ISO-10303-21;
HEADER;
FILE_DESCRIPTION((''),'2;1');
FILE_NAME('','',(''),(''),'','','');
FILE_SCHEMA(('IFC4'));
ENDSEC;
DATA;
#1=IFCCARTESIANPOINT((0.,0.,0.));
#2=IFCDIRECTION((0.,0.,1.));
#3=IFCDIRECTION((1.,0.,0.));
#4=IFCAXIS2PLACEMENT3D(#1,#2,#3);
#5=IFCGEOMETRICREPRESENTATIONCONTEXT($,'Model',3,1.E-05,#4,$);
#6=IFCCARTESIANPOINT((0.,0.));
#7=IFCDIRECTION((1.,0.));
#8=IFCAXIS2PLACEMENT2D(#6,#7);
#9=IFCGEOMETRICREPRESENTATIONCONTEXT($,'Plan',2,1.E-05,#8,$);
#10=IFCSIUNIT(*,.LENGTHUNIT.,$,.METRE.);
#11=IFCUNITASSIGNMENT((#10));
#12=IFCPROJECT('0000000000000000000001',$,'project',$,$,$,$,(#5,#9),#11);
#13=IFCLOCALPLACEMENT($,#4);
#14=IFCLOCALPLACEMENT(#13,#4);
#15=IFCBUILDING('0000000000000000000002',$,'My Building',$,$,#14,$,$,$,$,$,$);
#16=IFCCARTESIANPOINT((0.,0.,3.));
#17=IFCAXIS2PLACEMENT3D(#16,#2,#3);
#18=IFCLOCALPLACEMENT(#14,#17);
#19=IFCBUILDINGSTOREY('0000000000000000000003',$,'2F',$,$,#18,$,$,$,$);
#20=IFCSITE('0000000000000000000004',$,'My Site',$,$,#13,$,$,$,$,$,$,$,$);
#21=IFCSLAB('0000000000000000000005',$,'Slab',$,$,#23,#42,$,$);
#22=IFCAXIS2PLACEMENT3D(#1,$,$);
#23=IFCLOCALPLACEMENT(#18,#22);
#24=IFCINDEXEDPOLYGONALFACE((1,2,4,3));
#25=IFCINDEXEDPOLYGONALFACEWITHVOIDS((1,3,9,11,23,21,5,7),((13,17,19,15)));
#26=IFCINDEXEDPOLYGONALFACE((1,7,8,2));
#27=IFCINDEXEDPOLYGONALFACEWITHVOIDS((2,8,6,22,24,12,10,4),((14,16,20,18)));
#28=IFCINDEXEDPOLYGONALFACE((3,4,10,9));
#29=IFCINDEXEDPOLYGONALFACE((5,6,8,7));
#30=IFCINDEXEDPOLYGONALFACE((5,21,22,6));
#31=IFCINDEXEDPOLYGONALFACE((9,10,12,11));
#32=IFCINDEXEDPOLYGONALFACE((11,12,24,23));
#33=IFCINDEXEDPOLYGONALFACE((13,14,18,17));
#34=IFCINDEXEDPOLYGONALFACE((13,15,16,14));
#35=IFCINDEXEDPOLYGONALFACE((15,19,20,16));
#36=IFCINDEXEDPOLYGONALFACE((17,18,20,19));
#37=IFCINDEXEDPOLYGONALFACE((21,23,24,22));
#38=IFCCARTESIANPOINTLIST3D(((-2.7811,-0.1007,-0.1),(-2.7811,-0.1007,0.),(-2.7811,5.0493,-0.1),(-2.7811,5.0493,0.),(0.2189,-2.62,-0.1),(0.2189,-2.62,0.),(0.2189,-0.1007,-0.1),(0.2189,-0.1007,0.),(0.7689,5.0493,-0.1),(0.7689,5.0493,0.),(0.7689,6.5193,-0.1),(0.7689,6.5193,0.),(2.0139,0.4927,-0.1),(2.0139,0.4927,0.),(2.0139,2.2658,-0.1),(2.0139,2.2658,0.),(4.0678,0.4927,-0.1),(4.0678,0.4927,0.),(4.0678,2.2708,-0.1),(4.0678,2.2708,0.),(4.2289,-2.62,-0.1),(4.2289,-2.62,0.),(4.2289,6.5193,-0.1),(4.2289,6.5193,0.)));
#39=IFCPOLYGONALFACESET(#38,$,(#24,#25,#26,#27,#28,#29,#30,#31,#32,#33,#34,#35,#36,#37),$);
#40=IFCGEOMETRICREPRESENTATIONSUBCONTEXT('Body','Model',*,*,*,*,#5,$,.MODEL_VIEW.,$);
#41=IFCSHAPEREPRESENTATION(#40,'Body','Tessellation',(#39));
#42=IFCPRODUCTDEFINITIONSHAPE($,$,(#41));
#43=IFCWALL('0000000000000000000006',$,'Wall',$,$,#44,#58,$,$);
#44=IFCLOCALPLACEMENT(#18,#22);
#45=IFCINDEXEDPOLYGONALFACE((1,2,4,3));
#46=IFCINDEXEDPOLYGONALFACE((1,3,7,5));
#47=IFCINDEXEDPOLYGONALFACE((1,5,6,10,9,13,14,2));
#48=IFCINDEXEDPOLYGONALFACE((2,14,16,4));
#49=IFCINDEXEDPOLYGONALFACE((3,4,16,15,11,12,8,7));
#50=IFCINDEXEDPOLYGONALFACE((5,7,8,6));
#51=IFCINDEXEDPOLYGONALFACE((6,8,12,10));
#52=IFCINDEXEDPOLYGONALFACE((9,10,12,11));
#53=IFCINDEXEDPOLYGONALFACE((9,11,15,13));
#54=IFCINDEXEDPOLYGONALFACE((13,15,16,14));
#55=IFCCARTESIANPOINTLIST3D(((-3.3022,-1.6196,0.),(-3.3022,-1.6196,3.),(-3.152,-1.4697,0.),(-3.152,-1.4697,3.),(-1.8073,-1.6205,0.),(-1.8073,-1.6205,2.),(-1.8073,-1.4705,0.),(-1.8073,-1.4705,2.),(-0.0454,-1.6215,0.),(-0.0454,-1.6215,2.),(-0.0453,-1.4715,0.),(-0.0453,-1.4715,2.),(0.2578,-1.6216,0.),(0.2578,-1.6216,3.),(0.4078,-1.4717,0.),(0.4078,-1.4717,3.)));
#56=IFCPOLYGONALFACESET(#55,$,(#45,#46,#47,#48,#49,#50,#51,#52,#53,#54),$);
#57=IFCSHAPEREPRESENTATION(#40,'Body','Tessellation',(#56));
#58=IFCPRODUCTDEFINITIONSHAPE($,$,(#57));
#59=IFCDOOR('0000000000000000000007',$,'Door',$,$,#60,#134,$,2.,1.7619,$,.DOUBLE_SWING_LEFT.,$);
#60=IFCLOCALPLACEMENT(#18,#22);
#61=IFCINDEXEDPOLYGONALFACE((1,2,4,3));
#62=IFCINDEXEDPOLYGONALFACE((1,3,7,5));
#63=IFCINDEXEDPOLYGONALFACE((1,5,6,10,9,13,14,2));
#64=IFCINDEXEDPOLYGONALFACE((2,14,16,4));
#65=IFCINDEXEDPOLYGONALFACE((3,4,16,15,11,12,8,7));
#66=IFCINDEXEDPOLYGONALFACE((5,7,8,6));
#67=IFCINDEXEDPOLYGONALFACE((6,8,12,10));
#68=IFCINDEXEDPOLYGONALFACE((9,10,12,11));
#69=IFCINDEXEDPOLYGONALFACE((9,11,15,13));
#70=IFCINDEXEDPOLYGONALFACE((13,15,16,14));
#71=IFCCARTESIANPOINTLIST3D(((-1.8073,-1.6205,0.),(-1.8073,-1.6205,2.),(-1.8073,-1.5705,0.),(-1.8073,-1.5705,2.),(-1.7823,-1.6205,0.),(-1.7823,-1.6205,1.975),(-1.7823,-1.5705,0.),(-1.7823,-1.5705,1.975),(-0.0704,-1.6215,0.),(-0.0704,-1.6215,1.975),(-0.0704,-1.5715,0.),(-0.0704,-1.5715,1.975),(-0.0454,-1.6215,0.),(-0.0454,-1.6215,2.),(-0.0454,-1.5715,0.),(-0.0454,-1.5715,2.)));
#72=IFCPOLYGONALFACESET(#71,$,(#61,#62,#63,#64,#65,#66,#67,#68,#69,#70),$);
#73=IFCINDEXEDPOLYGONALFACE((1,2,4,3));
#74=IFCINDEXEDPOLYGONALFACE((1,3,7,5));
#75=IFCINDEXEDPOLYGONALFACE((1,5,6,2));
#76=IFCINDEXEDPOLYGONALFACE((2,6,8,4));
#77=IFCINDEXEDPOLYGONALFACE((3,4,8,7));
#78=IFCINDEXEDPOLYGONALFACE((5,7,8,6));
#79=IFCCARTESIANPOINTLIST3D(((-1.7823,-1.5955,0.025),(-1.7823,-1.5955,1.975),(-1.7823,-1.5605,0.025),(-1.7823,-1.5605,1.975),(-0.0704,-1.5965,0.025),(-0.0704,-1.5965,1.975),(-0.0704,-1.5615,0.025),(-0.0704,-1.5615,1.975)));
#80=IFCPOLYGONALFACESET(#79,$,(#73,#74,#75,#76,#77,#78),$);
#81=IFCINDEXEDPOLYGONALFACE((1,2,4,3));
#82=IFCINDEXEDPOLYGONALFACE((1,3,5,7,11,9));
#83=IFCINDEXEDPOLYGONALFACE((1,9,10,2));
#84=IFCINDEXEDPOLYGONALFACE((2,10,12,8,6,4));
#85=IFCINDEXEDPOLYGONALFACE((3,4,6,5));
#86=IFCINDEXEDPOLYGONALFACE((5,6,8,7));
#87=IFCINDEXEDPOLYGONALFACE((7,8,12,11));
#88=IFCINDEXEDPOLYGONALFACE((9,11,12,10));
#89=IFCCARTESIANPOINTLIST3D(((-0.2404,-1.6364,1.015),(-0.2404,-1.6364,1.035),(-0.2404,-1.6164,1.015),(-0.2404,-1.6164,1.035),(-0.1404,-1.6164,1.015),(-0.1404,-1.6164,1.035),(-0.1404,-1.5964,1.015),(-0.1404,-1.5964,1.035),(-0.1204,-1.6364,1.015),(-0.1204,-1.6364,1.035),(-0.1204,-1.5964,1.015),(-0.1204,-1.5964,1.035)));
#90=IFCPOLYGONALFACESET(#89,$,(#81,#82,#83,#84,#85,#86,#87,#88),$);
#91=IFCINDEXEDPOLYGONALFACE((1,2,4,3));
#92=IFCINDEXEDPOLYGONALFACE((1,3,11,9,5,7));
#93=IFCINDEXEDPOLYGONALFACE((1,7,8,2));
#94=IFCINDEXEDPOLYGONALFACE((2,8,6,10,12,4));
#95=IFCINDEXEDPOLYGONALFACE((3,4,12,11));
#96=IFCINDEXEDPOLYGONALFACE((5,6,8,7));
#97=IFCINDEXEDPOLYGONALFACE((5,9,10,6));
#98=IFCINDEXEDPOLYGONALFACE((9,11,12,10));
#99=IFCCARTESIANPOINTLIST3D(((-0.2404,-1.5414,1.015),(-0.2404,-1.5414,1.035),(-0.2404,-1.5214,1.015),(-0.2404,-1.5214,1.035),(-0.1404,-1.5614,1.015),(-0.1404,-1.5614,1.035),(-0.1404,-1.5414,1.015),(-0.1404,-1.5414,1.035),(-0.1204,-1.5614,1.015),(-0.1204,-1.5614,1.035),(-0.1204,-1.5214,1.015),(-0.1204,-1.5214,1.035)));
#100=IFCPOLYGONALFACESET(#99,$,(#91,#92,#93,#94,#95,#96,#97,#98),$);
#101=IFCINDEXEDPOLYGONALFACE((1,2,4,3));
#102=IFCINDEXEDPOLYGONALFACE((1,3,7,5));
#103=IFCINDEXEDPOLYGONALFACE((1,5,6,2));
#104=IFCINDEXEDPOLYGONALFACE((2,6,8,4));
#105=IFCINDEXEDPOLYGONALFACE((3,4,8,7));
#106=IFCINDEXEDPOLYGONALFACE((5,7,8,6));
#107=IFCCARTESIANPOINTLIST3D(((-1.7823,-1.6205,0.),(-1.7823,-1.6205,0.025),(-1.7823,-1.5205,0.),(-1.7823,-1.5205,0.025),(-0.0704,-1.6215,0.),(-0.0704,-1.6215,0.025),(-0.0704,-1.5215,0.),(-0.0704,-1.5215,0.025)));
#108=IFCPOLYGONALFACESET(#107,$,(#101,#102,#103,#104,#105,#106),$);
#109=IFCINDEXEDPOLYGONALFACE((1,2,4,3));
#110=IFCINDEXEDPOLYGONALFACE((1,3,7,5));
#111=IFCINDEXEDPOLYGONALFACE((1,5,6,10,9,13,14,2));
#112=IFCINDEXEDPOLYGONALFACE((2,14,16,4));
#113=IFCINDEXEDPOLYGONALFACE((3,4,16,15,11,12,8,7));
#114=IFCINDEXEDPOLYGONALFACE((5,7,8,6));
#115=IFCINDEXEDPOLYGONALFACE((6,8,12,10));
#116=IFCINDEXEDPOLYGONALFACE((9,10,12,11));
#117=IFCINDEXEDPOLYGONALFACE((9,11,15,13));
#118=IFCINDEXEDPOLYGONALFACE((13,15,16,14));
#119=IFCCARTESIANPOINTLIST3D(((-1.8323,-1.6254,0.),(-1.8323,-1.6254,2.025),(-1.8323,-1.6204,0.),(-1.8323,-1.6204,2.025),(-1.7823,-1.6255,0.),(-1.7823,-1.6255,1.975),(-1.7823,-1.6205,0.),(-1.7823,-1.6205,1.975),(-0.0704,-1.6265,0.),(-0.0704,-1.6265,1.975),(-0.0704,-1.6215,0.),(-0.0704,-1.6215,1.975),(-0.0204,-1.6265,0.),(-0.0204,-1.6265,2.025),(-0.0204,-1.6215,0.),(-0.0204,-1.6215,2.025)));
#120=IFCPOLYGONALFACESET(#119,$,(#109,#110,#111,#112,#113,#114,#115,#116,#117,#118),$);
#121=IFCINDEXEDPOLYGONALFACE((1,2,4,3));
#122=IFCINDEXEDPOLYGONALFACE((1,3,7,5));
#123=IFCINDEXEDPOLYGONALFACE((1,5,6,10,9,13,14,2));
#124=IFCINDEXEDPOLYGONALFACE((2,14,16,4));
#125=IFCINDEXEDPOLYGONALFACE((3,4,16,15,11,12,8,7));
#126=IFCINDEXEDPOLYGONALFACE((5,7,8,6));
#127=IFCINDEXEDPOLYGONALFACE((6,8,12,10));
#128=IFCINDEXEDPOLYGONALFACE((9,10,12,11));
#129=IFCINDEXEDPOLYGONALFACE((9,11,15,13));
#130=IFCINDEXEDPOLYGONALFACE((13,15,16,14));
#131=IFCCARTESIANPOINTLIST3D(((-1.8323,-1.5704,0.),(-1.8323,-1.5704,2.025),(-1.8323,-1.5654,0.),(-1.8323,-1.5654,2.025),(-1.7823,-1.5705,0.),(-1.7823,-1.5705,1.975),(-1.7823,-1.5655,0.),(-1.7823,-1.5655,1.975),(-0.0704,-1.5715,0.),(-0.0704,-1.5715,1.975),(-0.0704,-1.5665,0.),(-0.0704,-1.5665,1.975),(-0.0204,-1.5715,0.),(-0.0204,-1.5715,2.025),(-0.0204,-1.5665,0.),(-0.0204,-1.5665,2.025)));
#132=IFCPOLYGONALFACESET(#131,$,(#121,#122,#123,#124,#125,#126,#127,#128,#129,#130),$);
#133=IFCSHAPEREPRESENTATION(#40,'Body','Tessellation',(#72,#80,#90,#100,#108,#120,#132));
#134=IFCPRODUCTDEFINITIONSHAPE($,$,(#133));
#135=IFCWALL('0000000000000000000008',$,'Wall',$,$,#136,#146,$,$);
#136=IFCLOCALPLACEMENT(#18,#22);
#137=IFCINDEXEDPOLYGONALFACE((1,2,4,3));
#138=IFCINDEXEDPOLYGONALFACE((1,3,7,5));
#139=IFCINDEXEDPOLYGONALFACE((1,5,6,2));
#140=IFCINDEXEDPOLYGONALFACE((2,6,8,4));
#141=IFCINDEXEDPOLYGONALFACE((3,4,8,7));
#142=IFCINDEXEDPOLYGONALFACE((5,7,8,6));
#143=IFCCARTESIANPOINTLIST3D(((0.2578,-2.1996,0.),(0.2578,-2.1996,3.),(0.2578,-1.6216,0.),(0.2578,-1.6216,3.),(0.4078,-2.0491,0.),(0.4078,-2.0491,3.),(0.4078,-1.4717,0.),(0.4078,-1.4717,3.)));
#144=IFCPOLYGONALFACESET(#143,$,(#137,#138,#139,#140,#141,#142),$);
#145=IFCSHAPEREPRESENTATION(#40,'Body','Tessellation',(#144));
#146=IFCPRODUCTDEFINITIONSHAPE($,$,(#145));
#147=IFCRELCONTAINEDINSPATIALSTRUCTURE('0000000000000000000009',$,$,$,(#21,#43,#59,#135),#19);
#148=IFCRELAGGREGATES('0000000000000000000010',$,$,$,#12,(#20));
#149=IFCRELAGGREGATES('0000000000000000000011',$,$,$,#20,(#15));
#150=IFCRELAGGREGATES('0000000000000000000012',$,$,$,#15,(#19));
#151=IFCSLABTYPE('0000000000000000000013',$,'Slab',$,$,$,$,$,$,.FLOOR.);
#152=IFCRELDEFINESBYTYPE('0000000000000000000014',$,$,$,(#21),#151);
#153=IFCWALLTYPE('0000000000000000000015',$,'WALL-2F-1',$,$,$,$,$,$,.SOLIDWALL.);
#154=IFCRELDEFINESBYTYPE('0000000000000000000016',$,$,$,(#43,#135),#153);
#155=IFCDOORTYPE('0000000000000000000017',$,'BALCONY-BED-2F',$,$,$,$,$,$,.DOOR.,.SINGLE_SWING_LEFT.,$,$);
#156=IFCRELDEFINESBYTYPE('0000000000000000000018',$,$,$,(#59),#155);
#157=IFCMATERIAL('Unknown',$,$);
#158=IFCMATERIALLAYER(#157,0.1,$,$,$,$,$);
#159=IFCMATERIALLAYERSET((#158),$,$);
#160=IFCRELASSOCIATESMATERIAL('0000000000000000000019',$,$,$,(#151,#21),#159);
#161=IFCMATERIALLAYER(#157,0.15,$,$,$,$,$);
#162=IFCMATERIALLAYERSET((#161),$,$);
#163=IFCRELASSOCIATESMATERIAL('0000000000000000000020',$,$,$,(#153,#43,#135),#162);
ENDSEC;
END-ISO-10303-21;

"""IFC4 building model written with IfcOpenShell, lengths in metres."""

from ifc_helpers import new_model, entity, si_unit, frame, origin_with_axes, origin_2d_with_axis, place, context, subcontext, project, spatial, line, indexed_curve, outline, extrude, shape, source, transform, mapped, material, layer, layer_set, layer_usage, type_object, type_shapes, element, fill, save


model = new_model("IFC4")

# Units and contexts
model_context = context("Model", 3, precision=1e-05, world=origin_with_axes())
plan_context = context("Plan", 2, precision=1e-05, world=origin_2d_with_axis())
body_context_1 = subcontext(model_context, "Body", "Model", "MODEL_VIEW")
body_context_2 = subcontext(plan_context, "Body", "Plan", "PLAN_VIEW")
ifc_project = project(units=[si_unit("LENGTHUNIT", "METRE")], contexts=[model_context, plan_context])

# Site, building, storey
site_placement = place(None, origin_with_axes())
site = spatial("IfcSite", under=ifc_project, at=site_placement, Name="My Site")
building_placement = place(site_placement, origin_with_axes())
building = spatial("IfcBuilding", under=site, at=building_placement, Name="My Building")
storey_placement = place(building_placement, frame((0.0, 0.0, 3.0), z_axis=(0.0, 0.0, 1.0), x_axis=(1.0, 0.0, 0.0)))
storey = spatial("IfcBuildingStorey", under=building, at=storey_placement, Name="2F")

# Slab
ifc_material = material(Name="Unknown")
ifc_layer_1 = layer(ifc_material, 0.1)
ifc_layer_set_1 = layer_set([ifc_layer_1])
ifc_layer_usage_1 = layer_usage(ifc_layer_set_1, "AXIS3", "POSITIVE", -0.1)
slab_type = type_object("IfcSlabType", Name="Slab", PredefinedType="FLOOR", material=ifc_layer_set_1)
slab_placement = place(storey_placement, frame((0.2189, -2.62, 0.0), z_axis=(0.0, 0.0, 1.0), x_axis=(1.0, 0.0, 0.0)))
element("IfcSlab", 1, at=slab_placement, inside=storey, type_object=slab_type, material=ifc_layer_usage_1, Name="Slab", context=body_context_1, shape_type="SweptSolid", body=[
    extrude(outline(indexed_curve([(0.0, 0.0), (4.01, 0.0), (4.01, 9.1393), (0.55, 9.1393), (0.55, 7.6693), (-3.0, 7.6693), (-3.0, 2.5193), (0.0, 2.5193), (0.0, 0.0)]), holes=[indexed_curve([(1.7949, 4.8858), (3.8489, 4.8908), (3.8489, 3.1127), (1.7949, 3.1127), (1.7949, 4.8858)])]), frame((0.0, 0.0, -0.1), z_axis=(0.0, 0.0, 1.0), x_axis=(1.0, 0.0, 0.0)), (0.0, 0.0, 1.0), 0.1),
])

# Wall, opening, door
ifc_layer_2 = layer(ifc_material, 0.15)
ifc_layer_set_2 = layer_set([ifc_layer_2])
ifc_layer_usage_2 = layer_usage(ifc_layer_set_2, "AXIS2", "POSITIVE", 0.0)
wall_type_1 = type_object("IfcWallType", Name="WALL-2F-1", PredefinedType="SOLIDWALL", material=ifc_layer_set_2)
wall_1_placement = place(storey_placement, frame((-3.3022, -1.6196, 0.0), z_axis=(0.0, 0.0, 1.0), x_axis=(1.0, -0.00057, 0.0)))
wall_1 = element("IfcWall", 2, at=wall_1_placement, inside=storey, type_object=wall_type_1, material=ifc_layer_usage_2, Name="Wall", context=body_context_1, shape_type="SweptSolid", body=[
    extrude(outline(indexed_curve([(0.0, 0.0), (0.1501, 0.15), (3.7099, 0.15), (3.56, 0.0)], segments=[line(1, 2, 3, 4, 1)])), origin_with_axes(), (0.0, 0.0, 1.0), 3.0),
])
shared_shape_1 = source(origin_with_axes(), body_context_1, "Body", "SweptSolid", [
    extrude(outline(indexed_curve([(0.0, 0.0), (1.7619, 0.0), (1.7619, 2.0), (0.0, 2.0)], segments=[line(1, 2, 3, 4, 1)])), frame((0.0, -0.6, 0.0), z_axis=(0.0, -1.0, 0.0), x_axis=(1.0, 0.0, 0.0)), (0.0, 0.0, -1.0), 1.2),
])
opening_1_placement = place(wall_1_placement, frame((1.4948, 0.0, 0.0), z_axis=(0.0, 0.0, 1.0), x_axis=(1.0, 0.0, 0.0)))
opening_1 = element("IfcOpeningElement", 3, at=opening_1_placement, cuts=wall_1, PredefinedType="OPENING", context=body_context_1, shape_type="MappedRepresentation", body=[
    mapped(shared_shape_1, transform((0.0, 0.0, 0.0), x_axis=(1.0, 0.0, 0.0), y_axis=(0.0, 1.0, 0.0), z_axis=(0.0, 0.0, 1.0), scale=1.0)),
])
door_type_1 = type_object("IfcDoorType", Name="BALCONY-BED-2F", OperationType="SINGLE_SWING_LEFT", PredefinedType="DOOR")
shared_shape_2 = source(origin_with_axes(), body_context_1, "Body", "SweptSolid", [
    extrude(outline(indexed_curve([(0.0, 0.0), (0.0, 2.0), (1.7619, 2.0), (1.7619, 0.0), (1.7369, 0.0), (1.7369, 1.975), (0.025, 1.975), (0.025, 0.0)], segments=[line(1, 2, 3, 4, 5, 6, 7, 8, 1)])), frame((0.0, 0.0, 0.0), z_axis=(0.0, -1.0, 0.0), x_axis=(1.0, 0.0, 0.0)), (0.0, 0.0, -1.0), 0.05),
    extrude(outline(indexed_curve([(0.0, 0.0), (1.7119, 0.0), (1.7119, 0.035), (0.0, 0.035)], segments=[line(1, 2, 3, 4, 1)])), frame((0.025, 0.025, 0.025), z_axis=(0.0, 0.0, 1.0), x_axis=(1.0, 0.0, 0.0)), (0.0, 0.0, 1.0), 1.95),
    extrude(outline(indexed_curve([(0.0, 0.0), (0.0, -0.04), (-0.12, -0.04), (-0.12, -0.02), (-0.02, -0.02), (-0.02, 0.0)], segments=[line(1, 2, 3, 4, 5, 6, 1)])), frame((1.6869, 0.025, 1.015), z_axis=(0.0, 0.0, 1.0), x_axis=(1.0, 0.0, 0.0)), (0.0, 0.0, 1.0), 0.02),
    extrude(outline(indexed_curve([(0.0, 0.0), (0.0, 0.04), (-0.12, 0.04), (-0.12, 0.02), (-0.02, 0.02), (-0.02, 0.0)], segments=[line(1, 2, 3, 4, 5, 6, 1)])), frame((1.6869, 0.06, 1.015), z_axis=(0.0, 0.0, 1.0), x_axis=(1.0, 0.0, 0.0)), (0.0, 0.0, 1.0), 0.02),
    extrude(outline(indexed_curve([(0.0, 0.0), (1.7119, 0.0), (1.7119, 0.1), (0.0, 0.1)], segments=[line(1, 2, 3, 4, 1)])), frame((0.025, 0.0, 0.0), z_axis=(0.0, 0.0, 1.0), x_axis=(1.0, 0.0, 0.0)), (0.0, 0.0, 1.0), 0.025),
    extrude(outline(indexed_curve([(0.0, 0.0), (0.0, 2.025), (1.8119, 2.025), (1.8119, 0.0), (1.7619, 0.0), (1.7619, 1.975), (0.05, 1.975), (0.05, 0.0)], segments=[line(1, 2, 3, 4, 5, 6, 7, 8, 1)])), frame((-0.025, -0.005, 0.0), z_axis=(0.0, -1.0, 0.0), x_axis=(1.0, 0.0, 0.0)), (0.0, 0.0, -1.0), 0.005),
    extrude(outline(indexed_curve([(0.0, 0.0), (0.0, 2.025), (1.8119, 2.025), (1.8119, 0.0), (1.7619, 0.0), (1.7619, 1.975), (0.05, 1.975), (0.05, 0.0)], segments=[line(1, 2, 3, 4, 5, 6, 7, 8, 1)])), frame((-0.025, 0.05, 0.0), z_axis=(0.0, -1.0, 0.0), x_axis=(1.0, 0.0, 0.0)), (0.0, 0.0, -1.0), 0.005),
])
shared_shape_3 = source(origin_with_axes(), body_context_2, "Body", "Curve2D", [
    entity("IfcIndexedPolyCurve", entity("IfcCartesianPointList2D", [[0.0, 0.0], [0.025, 0.0], [0.025, 0.05], [0.0, 0.05]]), [entity("IfcLineIndex", [1, 2, 3, 4, 1])]),
    entity("IfcIndexedPolyCurve", entity("IfcCartesianPointList2D", [[1.7619, 0.0], [1.7369, 0.0], [1.7369, 0.05], [1.7619, 0.05]]), [entity("IfcLineIndex", [1, 2, 3, 4, 1])]),
    entity("IfcIndexedPolyCurve", entity("IfcCartesianPointList2D", [[0.025, 0.05], [0.025, -1.6619], [0.06, -1.6619]])),
    entity("IfcTrimmedCurve", entity("IfcEllipse", entity("IfcAxis2Placement2D", entity("IfcCartesianPoint", [0.06, 0.05]), entity("IfcDirection", [1.0, 0.0])), 1.6769, 1.7119), [entity("IfcCartesianPoint", [0.06, -1.6619])], [entity("IfcCartesianPoint", [0.06, 1.7619])], True, "CARTESIAN"),
    entity("IfcIndexedPolyCurve", entity("IfcCartesianPointList2D", [[0.025, 0.05], [0.06, 0.05], [0.06, 1.7619], [0.025, 1.7619]]), [entity("IfcLineIndex", [1, 2, 3, 4, 1])]),
])
type_shapes(door_type_1, [shared_shape_2, shared_shape_3])
door_1_placement = place(opening_1_placement, frame((0.0, 0.0, 0.0), z_axis=(0.0, 0.0, 1.0), x_axis=(1.0, 0.0, 0.0)))
door_1 = element("IfcDoor", 4, at=door_1_placement, inside=storey, type_object=door_type_1, Name="Door", OperationType="DOUBLE_SWING_LEFT", OverallHeight=2.0, OverallWidth=1.7619, shapes=[
    shape(body_context_1, "Body", "MappedRepresentation", [mapped(shared_shape_2, transform((0.0, 0.0, 0.0), x_axis=(1.0, 0.0, 0.0), y_axis=(0.0, 1.0, 0.0), z_axis=(0.0, 0.0, 1.0), scale=1.0))]),
    shape(body_context_2, "Body", "MappedRepresentation", [mapped(shared_shape_3, transform((0.0, 0.0, 0.0), x_axis=(1.0, 0.0, 0.0), y_axis=(0.0, 1.0, 0.0), z_axis=(0.0, 0.0, 1.0), scale=1.0))]),
])
fill(opening_1, door_1)

# Wall
ifc_layer_usage_3 = layer_usage(ifc_layer_set_2, "AXIS2", "POSITIVE", 0.0)
wall_2_placement = place(storey_placement, frame((0.2578, -1.6216, 0.0), z_axis=(0.0, 0.0, 1.0), x_axis=(0.0, -1.0, 0.0)))
element("IfcWall", 5, at=wall_2_placement, inside=storey, type_object=wall_type_1, material=ifc_layer_usage_3, Name="Wall", context=body_context_1, shape_type="SweptSolid", body=[
    extrude(outline(indexed_curve([(0.0, 0.0), (-0.1499, 0.15), (0.4275, 0.15), (0.578, 0.0)], segments=[line(1, 2, 3, 4, 1)])), origin_with_axes(), (0.0, 0.0, 1.0), 3.0),
])

save(model, "model.ifc")
